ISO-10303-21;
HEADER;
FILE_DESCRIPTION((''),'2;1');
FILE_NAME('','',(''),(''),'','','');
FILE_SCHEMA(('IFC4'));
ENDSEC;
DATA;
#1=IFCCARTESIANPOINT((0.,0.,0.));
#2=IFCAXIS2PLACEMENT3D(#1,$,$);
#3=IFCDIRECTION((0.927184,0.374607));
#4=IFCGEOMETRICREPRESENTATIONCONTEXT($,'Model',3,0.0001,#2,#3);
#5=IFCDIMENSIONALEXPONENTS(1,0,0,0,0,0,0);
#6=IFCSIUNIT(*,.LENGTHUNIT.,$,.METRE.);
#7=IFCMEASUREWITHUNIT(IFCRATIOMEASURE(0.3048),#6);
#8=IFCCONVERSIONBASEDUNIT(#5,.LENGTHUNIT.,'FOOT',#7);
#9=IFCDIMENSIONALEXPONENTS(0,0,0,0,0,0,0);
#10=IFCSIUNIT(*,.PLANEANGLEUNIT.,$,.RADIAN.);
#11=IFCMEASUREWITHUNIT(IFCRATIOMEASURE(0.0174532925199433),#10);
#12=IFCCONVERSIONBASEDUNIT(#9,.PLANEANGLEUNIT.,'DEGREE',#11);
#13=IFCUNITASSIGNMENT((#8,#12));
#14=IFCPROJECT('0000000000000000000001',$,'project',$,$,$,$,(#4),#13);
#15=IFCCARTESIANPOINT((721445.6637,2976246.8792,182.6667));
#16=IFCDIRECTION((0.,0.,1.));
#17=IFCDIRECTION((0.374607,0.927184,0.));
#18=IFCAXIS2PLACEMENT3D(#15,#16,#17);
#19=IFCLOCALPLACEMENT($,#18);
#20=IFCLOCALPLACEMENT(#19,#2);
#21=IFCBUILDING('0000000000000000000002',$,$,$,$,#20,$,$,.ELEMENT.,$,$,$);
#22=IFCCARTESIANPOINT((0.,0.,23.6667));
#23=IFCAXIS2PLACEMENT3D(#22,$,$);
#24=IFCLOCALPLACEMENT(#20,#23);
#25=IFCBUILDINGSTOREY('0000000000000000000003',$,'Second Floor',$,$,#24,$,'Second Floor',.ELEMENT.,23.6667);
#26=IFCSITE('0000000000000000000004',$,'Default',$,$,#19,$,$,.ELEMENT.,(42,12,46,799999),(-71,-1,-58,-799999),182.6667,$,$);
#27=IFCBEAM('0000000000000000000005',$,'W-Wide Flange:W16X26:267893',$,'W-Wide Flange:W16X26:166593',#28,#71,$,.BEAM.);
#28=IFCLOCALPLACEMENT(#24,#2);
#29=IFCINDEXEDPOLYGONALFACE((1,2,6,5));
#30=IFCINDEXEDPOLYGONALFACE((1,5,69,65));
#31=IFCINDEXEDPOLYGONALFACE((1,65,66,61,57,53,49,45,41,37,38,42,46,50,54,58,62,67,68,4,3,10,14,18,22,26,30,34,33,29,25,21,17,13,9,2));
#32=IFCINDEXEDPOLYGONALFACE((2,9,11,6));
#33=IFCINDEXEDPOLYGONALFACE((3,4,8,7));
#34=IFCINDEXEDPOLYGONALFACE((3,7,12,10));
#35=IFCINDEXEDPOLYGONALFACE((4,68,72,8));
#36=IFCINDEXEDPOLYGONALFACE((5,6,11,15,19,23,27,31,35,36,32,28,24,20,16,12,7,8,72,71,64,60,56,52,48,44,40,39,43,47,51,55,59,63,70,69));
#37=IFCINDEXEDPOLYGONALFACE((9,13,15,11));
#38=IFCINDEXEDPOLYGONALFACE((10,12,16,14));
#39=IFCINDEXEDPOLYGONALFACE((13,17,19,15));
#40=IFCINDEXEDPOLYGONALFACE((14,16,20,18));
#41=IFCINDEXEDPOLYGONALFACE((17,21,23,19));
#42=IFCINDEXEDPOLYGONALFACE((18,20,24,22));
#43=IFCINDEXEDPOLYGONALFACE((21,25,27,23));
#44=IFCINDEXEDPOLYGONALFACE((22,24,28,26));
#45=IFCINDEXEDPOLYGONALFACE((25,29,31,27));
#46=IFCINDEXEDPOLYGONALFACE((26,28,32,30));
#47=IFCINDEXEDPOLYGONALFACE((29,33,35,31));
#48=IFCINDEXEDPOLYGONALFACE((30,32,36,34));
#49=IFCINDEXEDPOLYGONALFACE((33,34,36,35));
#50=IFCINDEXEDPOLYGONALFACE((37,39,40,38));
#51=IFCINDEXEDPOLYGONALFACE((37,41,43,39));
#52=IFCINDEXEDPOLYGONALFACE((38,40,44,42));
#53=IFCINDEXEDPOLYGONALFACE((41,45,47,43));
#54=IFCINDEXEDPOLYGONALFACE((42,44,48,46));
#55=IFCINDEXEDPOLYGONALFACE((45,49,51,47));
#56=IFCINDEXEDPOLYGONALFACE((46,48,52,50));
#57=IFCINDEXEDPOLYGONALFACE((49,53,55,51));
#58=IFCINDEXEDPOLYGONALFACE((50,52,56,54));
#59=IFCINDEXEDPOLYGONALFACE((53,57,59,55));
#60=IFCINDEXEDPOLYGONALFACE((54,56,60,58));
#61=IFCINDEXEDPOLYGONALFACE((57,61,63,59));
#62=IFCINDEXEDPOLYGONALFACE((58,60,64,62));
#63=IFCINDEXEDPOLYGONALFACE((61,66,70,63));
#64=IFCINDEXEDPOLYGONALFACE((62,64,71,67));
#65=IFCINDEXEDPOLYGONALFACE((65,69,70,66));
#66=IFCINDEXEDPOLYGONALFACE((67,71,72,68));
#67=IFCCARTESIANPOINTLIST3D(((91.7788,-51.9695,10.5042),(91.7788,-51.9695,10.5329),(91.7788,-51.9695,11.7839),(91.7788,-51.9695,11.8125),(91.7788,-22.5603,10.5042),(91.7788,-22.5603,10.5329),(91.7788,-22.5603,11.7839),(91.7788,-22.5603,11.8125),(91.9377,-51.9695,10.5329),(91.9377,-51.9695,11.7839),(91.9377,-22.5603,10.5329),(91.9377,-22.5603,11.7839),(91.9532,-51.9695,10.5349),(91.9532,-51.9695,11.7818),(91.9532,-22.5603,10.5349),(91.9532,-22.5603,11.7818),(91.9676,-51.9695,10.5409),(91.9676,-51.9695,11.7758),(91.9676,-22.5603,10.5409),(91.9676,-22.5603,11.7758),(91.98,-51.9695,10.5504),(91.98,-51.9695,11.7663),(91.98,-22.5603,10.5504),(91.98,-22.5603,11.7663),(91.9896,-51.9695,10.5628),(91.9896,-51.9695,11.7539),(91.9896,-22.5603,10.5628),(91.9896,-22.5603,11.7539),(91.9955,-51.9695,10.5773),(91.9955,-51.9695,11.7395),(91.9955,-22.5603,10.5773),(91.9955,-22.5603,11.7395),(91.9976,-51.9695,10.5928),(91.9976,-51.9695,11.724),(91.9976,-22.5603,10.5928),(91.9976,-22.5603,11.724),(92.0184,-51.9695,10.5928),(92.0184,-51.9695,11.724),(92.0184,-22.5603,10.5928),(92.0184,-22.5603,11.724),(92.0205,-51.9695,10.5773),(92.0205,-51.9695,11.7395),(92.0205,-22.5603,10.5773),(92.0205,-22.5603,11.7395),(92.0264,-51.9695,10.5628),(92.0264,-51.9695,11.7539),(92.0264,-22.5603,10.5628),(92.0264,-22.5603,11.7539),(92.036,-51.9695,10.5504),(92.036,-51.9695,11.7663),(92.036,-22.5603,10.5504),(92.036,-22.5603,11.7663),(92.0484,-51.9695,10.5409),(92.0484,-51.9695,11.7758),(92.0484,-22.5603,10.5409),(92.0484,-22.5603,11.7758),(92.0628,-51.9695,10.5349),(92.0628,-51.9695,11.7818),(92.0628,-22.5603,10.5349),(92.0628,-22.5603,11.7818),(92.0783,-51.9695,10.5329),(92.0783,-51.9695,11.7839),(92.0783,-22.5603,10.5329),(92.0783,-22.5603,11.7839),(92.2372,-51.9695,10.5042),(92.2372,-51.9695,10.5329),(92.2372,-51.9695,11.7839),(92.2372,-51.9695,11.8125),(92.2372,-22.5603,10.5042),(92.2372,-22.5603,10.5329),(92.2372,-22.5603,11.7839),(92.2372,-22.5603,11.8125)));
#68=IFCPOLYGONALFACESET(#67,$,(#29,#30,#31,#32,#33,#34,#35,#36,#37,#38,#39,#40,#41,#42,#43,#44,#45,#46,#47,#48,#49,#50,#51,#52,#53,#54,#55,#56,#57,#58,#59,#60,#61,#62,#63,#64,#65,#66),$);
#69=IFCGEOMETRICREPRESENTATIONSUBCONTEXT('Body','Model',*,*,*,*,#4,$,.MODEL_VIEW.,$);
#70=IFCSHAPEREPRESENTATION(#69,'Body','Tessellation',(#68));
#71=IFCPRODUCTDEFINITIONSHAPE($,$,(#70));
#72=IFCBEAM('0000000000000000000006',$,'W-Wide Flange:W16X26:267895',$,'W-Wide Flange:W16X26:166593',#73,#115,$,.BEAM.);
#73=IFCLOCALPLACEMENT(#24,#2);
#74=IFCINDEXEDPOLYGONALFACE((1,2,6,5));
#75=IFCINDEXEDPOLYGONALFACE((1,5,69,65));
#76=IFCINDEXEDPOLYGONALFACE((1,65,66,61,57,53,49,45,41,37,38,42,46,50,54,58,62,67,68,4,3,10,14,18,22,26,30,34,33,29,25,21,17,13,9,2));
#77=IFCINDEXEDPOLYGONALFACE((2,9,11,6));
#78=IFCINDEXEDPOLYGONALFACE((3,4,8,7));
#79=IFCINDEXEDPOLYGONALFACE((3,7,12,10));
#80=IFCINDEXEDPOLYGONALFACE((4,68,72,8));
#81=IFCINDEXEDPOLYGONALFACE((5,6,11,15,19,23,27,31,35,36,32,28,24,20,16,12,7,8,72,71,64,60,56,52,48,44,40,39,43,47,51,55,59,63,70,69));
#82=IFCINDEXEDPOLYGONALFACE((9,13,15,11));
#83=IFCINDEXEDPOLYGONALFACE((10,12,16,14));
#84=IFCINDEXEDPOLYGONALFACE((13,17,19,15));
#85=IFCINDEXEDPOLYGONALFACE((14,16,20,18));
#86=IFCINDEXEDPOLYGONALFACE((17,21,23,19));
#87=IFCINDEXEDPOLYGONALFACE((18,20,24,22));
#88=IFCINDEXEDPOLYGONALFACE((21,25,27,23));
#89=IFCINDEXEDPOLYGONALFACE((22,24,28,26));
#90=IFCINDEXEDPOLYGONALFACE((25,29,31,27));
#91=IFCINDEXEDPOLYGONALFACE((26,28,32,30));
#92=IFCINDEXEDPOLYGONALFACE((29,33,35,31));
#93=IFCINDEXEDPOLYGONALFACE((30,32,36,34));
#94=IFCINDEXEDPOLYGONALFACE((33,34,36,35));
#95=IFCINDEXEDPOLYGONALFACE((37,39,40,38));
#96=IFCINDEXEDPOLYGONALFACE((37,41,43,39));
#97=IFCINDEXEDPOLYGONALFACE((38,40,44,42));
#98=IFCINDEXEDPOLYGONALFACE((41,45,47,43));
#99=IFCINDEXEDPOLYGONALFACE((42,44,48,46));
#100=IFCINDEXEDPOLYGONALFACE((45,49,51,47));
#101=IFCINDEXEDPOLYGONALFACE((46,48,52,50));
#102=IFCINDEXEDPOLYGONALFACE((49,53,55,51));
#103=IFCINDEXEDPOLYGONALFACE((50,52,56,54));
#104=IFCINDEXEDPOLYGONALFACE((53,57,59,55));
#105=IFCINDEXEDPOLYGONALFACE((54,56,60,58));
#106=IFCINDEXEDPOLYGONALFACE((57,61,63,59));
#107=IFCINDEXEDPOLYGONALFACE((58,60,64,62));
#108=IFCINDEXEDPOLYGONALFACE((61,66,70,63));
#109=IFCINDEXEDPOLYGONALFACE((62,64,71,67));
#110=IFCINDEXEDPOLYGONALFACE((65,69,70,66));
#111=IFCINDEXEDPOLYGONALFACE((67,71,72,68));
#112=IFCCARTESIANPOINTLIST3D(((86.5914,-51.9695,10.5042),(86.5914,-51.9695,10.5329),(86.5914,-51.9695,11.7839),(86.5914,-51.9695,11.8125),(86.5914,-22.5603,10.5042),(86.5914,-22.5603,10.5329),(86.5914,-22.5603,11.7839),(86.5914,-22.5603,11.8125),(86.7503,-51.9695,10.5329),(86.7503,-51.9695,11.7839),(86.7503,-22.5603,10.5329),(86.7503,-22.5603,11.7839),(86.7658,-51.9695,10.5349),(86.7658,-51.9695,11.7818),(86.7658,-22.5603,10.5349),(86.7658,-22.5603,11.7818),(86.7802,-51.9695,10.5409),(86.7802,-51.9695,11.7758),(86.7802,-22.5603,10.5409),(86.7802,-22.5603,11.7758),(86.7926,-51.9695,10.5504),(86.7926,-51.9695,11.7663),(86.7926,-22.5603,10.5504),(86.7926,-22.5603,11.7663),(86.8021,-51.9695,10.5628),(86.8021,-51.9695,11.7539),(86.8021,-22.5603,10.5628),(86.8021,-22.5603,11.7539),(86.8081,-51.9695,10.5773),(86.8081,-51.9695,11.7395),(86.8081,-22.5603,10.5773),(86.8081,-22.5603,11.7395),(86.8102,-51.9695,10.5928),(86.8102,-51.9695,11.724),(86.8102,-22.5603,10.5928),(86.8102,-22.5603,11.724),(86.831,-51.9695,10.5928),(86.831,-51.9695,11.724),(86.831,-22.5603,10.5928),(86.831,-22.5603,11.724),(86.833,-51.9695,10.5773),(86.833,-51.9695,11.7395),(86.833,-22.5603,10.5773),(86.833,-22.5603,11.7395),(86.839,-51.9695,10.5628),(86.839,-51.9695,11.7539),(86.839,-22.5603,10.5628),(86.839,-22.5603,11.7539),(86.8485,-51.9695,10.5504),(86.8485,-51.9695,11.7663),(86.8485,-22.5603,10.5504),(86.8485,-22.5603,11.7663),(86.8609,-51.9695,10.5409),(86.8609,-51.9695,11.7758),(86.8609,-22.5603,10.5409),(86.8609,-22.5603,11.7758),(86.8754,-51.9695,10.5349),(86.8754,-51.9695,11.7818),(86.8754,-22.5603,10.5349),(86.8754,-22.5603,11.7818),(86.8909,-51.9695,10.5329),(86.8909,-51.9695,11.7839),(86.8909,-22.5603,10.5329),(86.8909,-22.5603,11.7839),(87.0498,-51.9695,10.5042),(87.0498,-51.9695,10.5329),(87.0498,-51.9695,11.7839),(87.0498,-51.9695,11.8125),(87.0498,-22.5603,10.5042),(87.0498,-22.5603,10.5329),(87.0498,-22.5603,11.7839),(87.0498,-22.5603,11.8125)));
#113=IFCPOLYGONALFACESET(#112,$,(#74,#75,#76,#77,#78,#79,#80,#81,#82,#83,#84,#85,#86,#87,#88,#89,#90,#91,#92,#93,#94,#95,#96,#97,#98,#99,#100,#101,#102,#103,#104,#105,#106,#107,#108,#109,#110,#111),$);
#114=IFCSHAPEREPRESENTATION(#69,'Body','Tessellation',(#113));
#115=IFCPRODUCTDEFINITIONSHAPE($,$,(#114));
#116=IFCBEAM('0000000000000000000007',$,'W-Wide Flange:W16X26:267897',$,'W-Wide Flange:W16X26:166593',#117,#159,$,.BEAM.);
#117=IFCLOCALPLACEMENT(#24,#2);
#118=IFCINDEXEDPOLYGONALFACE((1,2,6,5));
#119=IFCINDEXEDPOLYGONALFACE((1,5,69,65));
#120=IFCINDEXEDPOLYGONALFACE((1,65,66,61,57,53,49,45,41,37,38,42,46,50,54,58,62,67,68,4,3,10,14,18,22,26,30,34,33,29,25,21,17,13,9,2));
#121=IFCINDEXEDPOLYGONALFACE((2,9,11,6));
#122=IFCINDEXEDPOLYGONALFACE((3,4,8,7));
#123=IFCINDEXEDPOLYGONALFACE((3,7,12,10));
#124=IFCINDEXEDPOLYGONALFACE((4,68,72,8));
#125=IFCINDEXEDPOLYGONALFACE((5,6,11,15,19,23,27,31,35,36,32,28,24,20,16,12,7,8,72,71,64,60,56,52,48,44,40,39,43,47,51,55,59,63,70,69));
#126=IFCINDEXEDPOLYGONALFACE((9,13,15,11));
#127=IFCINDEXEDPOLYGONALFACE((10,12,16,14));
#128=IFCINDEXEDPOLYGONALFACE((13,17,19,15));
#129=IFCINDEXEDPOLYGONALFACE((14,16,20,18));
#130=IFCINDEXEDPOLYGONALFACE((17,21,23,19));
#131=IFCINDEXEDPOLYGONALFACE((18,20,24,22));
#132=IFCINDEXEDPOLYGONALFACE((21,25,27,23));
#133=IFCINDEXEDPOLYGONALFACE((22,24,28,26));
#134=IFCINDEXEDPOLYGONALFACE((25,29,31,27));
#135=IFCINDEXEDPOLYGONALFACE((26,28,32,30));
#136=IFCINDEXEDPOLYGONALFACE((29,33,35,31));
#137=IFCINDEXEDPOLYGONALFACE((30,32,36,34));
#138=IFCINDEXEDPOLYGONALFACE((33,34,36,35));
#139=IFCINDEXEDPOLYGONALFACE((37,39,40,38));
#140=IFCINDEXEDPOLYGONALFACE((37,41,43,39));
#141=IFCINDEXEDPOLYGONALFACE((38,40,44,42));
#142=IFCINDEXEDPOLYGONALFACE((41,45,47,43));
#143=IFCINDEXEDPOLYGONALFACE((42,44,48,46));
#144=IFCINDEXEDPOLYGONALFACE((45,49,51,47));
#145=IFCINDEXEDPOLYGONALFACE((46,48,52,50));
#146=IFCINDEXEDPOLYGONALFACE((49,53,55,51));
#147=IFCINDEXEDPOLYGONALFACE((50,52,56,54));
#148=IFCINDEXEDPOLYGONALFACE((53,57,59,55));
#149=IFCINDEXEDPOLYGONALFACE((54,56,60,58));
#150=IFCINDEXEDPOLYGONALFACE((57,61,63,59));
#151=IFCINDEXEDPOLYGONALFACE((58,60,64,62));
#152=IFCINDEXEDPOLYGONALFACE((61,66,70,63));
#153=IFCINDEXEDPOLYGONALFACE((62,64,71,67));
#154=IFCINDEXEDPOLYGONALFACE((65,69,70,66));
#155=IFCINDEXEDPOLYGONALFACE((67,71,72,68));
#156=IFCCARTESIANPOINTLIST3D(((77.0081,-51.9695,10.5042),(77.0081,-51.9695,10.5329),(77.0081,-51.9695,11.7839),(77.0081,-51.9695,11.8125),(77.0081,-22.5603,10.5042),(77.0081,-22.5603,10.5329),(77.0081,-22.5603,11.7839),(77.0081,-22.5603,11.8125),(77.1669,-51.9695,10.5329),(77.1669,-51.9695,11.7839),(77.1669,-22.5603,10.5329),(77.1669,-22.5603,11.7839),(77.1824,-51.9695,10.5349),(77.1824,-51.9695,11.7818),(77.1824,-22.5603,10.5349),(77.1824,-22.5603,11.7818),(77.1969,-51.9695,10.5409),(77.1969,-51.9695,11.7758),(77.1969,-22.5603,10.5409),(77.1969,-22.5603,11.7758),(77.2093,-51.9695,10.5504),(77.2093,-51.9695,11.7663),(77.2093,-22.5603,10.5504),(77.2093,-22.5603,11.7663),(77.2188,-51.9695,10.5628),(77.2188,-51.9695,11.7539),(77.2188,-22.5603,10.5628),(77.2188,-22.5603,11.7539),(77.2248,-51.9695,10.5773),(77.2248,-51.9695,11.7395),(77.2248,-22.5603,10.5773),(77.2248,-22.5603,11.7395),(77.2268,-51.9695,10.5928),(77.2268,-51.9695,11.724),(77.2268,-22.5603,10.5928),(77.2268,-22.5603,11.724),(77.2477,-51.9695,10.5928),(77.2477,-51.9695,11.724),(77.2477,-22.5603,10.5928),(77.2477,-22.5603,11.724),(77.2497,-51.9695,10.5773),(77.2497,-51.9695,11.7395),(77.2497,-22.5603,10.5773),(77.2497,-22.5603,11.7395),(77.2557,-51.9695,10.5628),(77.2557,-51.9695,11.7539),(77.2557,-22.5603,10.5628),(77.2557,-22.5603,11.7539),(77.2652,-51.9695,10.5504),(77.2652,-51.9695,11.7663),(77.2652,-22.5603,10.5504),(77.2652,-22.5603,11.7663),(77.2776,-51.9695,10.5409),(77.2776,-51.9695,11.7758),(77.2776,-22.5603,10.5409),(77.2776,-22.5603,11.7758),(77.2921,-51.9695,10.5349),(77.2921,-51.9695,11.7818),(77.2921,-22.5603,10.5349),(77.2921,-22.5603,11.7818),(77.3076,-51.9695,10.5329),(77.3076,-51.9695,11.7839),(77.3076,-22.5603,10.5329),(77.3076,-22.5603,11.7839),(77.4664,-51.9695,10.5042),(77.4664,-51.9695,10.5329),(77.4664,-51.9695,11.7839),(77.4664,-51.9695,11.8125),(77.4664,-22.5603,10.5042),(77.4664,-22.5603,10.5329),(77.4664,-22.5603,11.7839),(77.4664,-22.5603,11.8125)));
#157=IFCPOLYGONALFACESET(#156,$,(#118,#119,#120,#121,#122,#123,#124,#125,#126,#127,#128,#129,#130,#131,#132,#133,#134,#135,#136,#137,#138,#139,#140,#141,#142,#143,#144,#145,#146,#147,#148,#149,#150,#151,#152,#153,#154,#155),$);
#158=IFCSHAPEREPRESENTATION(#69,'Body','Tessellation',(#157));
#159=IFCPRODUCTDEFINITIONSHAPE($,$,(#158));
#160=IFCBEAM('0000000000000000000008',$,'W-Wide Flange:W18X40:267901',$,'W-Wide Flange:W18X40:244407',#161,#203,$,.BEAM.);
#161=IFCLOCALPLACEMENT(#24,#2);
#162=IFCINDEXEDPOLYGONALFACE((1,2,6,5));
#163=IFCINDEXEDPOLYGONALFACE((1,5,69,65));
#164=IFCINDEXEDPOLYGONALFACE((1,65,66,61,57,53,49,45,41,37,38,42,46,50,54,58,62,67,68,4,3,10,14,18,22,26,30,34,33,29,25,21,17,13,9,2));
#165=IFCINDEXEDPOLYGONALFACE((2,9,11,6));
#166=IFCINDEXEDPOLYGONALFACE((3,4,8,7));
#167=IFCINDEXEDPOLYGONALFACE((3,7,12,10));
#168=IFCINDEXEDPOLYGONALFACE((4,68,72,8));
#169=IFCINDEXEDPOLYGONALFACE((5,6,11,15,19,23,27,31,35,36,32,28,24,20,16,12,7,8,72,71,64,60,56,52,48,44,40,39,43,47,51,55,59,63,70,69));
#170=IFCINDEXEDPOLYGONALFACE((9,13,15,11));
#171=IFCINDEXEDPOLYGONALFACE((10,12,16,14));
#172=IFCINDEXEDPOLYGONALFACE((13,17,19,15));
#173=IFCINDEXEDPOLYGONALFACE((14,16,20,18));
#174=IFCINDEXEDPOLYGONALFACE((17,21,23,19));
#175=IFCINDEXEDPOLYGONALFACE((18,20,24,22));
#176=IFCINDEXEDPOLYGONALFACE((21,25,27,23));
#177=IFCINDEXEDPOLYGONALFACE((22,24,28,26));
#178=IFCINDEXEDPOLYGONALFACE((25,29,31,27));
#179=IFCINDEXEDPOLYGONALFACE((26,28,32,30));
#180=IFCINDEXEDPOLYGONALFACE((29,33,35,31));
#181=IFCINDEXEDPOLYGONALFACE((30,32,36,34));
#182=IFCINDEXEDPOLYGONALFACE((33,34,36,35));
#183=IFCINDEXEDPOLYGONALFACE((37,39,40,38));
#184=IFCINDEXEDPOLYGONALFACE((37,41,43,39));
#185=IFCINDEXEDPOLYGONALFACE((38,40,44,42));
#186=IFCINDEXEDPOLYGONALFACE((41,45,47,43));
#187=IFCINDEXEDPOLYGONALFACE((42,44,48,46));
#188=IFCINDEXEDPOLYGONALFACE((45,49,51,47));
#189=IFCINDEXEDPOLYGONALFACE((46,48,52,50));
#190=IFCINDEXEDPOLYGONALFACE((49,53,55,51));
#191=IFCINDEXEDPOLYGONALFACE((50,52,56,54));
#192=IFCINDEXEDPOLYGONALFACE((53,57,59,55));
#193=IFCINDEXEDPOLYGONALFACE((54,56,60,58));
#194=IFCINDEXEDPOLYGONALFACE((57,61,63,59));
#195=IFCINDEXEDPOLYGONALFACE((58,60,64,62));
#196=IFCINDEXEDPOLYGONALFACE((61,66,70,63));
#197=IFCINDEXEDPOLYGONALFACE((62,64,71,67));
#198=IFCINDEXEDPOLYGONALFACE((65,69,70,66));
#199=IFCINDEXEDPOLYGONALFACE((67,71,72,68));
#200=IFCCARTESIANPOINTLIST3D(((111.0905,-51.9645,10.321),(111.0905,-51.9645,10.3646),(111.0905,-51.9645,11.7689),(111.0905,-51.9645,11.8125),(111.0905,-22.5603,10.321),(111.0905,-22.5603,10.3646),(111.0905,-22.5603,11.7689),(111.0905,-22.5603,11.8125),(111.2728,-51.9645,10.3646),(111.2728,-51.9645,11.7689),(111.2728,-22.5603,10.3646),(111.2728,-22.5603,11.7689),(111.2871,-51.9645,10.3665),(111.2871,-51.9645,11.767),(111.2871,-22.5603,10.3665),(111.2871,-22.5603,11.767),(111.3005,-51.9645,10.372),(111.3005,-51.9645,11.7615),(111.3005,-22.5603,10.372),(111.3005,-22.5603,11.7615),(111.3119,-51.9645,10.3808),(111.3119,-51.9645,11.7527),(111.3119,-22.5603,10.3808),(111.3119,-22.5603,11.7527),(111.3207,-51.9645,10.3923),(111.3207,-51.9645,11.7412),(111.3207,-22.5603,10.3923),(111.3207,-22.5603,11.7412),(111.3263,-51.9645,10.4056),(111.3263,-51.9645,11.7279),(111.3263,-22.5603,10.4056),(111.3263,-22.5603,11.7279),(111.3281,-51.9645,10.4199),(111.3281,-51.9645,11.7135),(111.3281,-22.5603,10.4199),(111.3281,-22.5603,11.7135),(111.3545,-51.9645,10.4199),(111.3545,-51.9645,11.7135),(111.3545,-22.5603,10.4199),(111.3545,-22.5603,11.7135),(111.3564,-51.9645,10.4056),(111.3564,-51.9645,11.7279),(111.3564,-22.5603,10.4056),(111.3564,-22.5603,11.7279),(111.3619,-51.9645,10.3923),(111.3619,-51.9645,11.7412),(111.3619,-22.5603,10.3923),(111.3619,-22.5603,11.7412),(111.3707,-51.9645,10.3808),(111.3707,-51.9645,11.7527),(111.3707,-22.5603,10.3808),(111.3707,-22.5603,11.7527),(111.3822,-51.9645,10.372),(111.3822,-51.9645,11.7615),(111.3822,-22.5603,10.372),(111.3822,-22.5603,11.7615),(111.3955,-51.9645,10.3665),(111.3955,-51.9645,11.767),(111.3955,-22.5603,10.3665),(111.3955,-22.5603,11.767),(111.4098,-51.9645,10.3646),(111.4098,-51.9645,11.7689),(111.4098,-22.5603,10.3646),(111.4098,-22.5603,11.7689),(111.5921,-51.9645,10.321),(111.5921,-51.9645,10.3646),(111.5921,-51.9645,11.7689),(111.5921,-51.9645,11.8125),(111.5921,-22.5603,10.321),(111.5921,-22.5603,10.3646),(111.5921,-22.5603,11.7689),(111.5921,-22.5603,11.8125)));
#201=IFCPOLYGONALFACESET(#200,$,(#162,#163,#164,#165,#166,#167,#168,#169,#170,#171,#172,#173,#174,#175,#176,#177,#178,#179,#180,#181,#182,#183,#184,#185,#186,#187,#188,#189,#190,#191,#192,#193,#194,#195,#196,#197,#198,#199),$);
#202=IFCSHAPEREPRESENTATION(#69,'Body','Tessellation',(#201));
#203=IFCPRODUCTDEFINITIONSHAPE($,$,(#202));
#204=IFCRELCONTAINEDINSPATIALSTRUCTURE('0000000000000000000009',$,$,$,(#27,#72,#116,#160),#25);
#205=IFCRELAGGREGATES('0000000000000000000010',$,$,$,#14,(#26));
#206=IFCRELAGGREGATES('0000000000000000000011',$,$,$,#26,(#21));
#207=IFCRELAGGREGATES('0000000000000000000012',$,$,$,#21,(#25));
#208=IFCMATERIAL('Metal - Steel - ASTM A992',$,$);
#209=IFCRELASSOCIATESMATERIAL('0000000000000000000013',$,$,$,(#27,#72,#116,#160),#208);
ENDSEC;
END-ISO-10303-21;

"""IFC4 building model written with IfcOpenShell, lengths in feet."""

from ifc_helpers import new_model, entity, si_unit, converted_unit, direction, frame, frame_2d, origin, place, context, subcontext, project, spatial, i_section, extrude, material, element, save


model = new_model("IFC4")

# Units and contexts
model_context = context("Model", 3, precision=0.0001, world=origin(), true_north=direction((0.927184, 0.374607)))
body_context = subcontext(model_context, "Body", "Model", "MODEL_VIEW")
ifc_project = project(units=[converted_unit("LENGTHUNIT", "FOOT", entity("IfcRatioMeasure", 0.3048), si_unit("LENGTHUNIT", "METRE"), dimensions=[1, 0, 0, 0, 0, 0, 0]), converted_unit("PLANEANGLEUNIT", "DEGREE", entity("IfcRatioMeasure", 0.0174532925199433), si_unit("PLANEANGLEUNIT", "RADIAN"), dimensions=[0, 0, 0, 0, 0, 0, 0])], contexts=[model_context])

# Site, building, storey
site_placement = place(None, frame((721445.6637, 2976246.8792, 182.6667), z_axis=(0.0, 0.0, 1.0), x_axis=(0.374607, 0.927184, 0.0)))
site = spatial("IfcSite", under=ifc_project, at=site_placement, Name="Default", CompositionType="ELEMENT", RefLatitude=(42, 12, 46, 799999), RefLongitude=(-71, -1, -58, -799999), RefElevation=182.6667)
building_placement = place(site_placement, origin())
building = spatial("IfcBuilding", under=site, at=building_placement, CompositionType="ELEMENT")
storey_placement = place(building_placement, frame((0.0, 0.0, 23.6667)))
storey = spatial("IfcBuildingStorey", under=building, at=storey_placement, Name="Second Floor", LongName="Second Floor", CompositionType="ELEMENT", Elevation=23.6667)

# Shared definitions
ifc_material_1 = material(Name="Metal - Steel - ASTM A992")

# Beams
beam_1_placement = place(storey_placement, frame((92.008, -52.3544, 11.8125), z_axis=(0.0, 0.0, 1.0), x_axis=(0.0, 1.0, 0.0)))
element("IfcBeam", 1, at=beam_1_placement, inside=storey, material=ifc_material_1, Name="W-Wide Flange:W16X26:267893", ObjectType="W-Wide Flange:W16X26:166593", PredefinedType="BEAM", context=body_context, shape_type="SweptSolid", body=[
    extrude(i_section(OverallWidth=0.4583, OverallDepth=1.3083, WebThickness=0.0208, FlangeThickness=0.0286, FilletRadius=0.0599, at=frame_2d((0.0, 0.0), x_axis=(0.0, 1.0))), frame((0.3849, 0.0, -0.6541), z_axis=(1.0, 0.0, 0.0), x_axis=(0.0, 0.0, -1.0)), (0.0, 0.0, 1.0), 29.4092),
])
beam_2_placement = place(storey_placement, frame((86.8206, -52.3544, 11.8125), z_axis=(0.0, 0.0, 1.0), x_axis=(0.0, 1.0, 0.0)))
element("IfcBeam", 2, at=beam_2_placement, inside=storey, material=ifc_material_1, Name="W-Wide Flange:W16X26:267895", ObjectType="W-Wide Flange:W16X26:166593", PredefinedType="BEAM", context=body_context, shape_type="SweptSolid", body=[
    extrude(i_section(OverallWidth=0.4583, OverallDepth=1.3083, WebThickness=0.0208, FlangeThickness=0.0286, FilletRadius=0.0599, at=frame_2d((0.0, 0.0), x_axis=(0.0, 1.0))), frame((0.3849, 0.0, -0.6541), z_axis=(1.0, 0.0, 0.0), x_axis=(0.0, 0.0, -1.0)), (0.0, 0.0, 1.0), 29.4092),
])
beam_3_placement = place(storey_placement, frame((77.2373, -52.3544, 11.8125), z_axis=(0.0, 0.0, 1.0), x_axis=(0.0, 1.0, 0.0)))
element("IfcBeam", 3, at=beam_3_placement, inside=storey, material=ifc_material_1, Name="W-Wide Flange:W16X26:267897", ObjectType="W-Wide Flange:W16X26:166593", PredefinedType="BEAM", context=body_context, shape_type="SweptSolid", body=[
    extrude(i_section(OverallWidth=0.4583, OverallDepth=1.3083, WebThickness=0.0208, FlangeThickness=0.0286, FilletRadius=0.0599, at=frame_2d((0.0, 0.0), x_axis=(0.0, 1.0))), frame((0.3849, 0.0, -0.6541), z_axis=(1.0, 0.0, 0.0), x_axis=(0.0, 0.0, -1.0)), (0.0, 0.0, 1.0), 29.4092),
])
beam_4_placement = place(storey_placement, frame((111.3413, -52.3544, 11.8125), z_axis=(0.0, 0.0, 1.0), x_axis=(0.0, 1.0, 0.0)))
element("IfcBeam", 4, at=beam_4_placement, inside=storey, material=ifc_material_1, Name="W-Wide Flange:W18X40:267901", ObjectType="W-Wide Flange:W18X40:244407", PredefinedType="BEAM", context=body_context, shape_type="SweptSolid", body=[
    extrude(i_section(OverallWidth=0.5016, OverallDepth=1.4915, WebThickness=0.0264, FlangeThickness=0.0436, FilletRadius=0.0553, at=frame_2d((0.0, 0.0), x_axis=(0.0, 1.0))), frame((0.39, 0.0, -0.7458), z_axis=(1.0, 0.0, 0.0), x_axis=(0.0, 0.0, -1.0)), (0.0, 0.0, 1.0), 29.4041),
])

save(model, "model.ifc")
